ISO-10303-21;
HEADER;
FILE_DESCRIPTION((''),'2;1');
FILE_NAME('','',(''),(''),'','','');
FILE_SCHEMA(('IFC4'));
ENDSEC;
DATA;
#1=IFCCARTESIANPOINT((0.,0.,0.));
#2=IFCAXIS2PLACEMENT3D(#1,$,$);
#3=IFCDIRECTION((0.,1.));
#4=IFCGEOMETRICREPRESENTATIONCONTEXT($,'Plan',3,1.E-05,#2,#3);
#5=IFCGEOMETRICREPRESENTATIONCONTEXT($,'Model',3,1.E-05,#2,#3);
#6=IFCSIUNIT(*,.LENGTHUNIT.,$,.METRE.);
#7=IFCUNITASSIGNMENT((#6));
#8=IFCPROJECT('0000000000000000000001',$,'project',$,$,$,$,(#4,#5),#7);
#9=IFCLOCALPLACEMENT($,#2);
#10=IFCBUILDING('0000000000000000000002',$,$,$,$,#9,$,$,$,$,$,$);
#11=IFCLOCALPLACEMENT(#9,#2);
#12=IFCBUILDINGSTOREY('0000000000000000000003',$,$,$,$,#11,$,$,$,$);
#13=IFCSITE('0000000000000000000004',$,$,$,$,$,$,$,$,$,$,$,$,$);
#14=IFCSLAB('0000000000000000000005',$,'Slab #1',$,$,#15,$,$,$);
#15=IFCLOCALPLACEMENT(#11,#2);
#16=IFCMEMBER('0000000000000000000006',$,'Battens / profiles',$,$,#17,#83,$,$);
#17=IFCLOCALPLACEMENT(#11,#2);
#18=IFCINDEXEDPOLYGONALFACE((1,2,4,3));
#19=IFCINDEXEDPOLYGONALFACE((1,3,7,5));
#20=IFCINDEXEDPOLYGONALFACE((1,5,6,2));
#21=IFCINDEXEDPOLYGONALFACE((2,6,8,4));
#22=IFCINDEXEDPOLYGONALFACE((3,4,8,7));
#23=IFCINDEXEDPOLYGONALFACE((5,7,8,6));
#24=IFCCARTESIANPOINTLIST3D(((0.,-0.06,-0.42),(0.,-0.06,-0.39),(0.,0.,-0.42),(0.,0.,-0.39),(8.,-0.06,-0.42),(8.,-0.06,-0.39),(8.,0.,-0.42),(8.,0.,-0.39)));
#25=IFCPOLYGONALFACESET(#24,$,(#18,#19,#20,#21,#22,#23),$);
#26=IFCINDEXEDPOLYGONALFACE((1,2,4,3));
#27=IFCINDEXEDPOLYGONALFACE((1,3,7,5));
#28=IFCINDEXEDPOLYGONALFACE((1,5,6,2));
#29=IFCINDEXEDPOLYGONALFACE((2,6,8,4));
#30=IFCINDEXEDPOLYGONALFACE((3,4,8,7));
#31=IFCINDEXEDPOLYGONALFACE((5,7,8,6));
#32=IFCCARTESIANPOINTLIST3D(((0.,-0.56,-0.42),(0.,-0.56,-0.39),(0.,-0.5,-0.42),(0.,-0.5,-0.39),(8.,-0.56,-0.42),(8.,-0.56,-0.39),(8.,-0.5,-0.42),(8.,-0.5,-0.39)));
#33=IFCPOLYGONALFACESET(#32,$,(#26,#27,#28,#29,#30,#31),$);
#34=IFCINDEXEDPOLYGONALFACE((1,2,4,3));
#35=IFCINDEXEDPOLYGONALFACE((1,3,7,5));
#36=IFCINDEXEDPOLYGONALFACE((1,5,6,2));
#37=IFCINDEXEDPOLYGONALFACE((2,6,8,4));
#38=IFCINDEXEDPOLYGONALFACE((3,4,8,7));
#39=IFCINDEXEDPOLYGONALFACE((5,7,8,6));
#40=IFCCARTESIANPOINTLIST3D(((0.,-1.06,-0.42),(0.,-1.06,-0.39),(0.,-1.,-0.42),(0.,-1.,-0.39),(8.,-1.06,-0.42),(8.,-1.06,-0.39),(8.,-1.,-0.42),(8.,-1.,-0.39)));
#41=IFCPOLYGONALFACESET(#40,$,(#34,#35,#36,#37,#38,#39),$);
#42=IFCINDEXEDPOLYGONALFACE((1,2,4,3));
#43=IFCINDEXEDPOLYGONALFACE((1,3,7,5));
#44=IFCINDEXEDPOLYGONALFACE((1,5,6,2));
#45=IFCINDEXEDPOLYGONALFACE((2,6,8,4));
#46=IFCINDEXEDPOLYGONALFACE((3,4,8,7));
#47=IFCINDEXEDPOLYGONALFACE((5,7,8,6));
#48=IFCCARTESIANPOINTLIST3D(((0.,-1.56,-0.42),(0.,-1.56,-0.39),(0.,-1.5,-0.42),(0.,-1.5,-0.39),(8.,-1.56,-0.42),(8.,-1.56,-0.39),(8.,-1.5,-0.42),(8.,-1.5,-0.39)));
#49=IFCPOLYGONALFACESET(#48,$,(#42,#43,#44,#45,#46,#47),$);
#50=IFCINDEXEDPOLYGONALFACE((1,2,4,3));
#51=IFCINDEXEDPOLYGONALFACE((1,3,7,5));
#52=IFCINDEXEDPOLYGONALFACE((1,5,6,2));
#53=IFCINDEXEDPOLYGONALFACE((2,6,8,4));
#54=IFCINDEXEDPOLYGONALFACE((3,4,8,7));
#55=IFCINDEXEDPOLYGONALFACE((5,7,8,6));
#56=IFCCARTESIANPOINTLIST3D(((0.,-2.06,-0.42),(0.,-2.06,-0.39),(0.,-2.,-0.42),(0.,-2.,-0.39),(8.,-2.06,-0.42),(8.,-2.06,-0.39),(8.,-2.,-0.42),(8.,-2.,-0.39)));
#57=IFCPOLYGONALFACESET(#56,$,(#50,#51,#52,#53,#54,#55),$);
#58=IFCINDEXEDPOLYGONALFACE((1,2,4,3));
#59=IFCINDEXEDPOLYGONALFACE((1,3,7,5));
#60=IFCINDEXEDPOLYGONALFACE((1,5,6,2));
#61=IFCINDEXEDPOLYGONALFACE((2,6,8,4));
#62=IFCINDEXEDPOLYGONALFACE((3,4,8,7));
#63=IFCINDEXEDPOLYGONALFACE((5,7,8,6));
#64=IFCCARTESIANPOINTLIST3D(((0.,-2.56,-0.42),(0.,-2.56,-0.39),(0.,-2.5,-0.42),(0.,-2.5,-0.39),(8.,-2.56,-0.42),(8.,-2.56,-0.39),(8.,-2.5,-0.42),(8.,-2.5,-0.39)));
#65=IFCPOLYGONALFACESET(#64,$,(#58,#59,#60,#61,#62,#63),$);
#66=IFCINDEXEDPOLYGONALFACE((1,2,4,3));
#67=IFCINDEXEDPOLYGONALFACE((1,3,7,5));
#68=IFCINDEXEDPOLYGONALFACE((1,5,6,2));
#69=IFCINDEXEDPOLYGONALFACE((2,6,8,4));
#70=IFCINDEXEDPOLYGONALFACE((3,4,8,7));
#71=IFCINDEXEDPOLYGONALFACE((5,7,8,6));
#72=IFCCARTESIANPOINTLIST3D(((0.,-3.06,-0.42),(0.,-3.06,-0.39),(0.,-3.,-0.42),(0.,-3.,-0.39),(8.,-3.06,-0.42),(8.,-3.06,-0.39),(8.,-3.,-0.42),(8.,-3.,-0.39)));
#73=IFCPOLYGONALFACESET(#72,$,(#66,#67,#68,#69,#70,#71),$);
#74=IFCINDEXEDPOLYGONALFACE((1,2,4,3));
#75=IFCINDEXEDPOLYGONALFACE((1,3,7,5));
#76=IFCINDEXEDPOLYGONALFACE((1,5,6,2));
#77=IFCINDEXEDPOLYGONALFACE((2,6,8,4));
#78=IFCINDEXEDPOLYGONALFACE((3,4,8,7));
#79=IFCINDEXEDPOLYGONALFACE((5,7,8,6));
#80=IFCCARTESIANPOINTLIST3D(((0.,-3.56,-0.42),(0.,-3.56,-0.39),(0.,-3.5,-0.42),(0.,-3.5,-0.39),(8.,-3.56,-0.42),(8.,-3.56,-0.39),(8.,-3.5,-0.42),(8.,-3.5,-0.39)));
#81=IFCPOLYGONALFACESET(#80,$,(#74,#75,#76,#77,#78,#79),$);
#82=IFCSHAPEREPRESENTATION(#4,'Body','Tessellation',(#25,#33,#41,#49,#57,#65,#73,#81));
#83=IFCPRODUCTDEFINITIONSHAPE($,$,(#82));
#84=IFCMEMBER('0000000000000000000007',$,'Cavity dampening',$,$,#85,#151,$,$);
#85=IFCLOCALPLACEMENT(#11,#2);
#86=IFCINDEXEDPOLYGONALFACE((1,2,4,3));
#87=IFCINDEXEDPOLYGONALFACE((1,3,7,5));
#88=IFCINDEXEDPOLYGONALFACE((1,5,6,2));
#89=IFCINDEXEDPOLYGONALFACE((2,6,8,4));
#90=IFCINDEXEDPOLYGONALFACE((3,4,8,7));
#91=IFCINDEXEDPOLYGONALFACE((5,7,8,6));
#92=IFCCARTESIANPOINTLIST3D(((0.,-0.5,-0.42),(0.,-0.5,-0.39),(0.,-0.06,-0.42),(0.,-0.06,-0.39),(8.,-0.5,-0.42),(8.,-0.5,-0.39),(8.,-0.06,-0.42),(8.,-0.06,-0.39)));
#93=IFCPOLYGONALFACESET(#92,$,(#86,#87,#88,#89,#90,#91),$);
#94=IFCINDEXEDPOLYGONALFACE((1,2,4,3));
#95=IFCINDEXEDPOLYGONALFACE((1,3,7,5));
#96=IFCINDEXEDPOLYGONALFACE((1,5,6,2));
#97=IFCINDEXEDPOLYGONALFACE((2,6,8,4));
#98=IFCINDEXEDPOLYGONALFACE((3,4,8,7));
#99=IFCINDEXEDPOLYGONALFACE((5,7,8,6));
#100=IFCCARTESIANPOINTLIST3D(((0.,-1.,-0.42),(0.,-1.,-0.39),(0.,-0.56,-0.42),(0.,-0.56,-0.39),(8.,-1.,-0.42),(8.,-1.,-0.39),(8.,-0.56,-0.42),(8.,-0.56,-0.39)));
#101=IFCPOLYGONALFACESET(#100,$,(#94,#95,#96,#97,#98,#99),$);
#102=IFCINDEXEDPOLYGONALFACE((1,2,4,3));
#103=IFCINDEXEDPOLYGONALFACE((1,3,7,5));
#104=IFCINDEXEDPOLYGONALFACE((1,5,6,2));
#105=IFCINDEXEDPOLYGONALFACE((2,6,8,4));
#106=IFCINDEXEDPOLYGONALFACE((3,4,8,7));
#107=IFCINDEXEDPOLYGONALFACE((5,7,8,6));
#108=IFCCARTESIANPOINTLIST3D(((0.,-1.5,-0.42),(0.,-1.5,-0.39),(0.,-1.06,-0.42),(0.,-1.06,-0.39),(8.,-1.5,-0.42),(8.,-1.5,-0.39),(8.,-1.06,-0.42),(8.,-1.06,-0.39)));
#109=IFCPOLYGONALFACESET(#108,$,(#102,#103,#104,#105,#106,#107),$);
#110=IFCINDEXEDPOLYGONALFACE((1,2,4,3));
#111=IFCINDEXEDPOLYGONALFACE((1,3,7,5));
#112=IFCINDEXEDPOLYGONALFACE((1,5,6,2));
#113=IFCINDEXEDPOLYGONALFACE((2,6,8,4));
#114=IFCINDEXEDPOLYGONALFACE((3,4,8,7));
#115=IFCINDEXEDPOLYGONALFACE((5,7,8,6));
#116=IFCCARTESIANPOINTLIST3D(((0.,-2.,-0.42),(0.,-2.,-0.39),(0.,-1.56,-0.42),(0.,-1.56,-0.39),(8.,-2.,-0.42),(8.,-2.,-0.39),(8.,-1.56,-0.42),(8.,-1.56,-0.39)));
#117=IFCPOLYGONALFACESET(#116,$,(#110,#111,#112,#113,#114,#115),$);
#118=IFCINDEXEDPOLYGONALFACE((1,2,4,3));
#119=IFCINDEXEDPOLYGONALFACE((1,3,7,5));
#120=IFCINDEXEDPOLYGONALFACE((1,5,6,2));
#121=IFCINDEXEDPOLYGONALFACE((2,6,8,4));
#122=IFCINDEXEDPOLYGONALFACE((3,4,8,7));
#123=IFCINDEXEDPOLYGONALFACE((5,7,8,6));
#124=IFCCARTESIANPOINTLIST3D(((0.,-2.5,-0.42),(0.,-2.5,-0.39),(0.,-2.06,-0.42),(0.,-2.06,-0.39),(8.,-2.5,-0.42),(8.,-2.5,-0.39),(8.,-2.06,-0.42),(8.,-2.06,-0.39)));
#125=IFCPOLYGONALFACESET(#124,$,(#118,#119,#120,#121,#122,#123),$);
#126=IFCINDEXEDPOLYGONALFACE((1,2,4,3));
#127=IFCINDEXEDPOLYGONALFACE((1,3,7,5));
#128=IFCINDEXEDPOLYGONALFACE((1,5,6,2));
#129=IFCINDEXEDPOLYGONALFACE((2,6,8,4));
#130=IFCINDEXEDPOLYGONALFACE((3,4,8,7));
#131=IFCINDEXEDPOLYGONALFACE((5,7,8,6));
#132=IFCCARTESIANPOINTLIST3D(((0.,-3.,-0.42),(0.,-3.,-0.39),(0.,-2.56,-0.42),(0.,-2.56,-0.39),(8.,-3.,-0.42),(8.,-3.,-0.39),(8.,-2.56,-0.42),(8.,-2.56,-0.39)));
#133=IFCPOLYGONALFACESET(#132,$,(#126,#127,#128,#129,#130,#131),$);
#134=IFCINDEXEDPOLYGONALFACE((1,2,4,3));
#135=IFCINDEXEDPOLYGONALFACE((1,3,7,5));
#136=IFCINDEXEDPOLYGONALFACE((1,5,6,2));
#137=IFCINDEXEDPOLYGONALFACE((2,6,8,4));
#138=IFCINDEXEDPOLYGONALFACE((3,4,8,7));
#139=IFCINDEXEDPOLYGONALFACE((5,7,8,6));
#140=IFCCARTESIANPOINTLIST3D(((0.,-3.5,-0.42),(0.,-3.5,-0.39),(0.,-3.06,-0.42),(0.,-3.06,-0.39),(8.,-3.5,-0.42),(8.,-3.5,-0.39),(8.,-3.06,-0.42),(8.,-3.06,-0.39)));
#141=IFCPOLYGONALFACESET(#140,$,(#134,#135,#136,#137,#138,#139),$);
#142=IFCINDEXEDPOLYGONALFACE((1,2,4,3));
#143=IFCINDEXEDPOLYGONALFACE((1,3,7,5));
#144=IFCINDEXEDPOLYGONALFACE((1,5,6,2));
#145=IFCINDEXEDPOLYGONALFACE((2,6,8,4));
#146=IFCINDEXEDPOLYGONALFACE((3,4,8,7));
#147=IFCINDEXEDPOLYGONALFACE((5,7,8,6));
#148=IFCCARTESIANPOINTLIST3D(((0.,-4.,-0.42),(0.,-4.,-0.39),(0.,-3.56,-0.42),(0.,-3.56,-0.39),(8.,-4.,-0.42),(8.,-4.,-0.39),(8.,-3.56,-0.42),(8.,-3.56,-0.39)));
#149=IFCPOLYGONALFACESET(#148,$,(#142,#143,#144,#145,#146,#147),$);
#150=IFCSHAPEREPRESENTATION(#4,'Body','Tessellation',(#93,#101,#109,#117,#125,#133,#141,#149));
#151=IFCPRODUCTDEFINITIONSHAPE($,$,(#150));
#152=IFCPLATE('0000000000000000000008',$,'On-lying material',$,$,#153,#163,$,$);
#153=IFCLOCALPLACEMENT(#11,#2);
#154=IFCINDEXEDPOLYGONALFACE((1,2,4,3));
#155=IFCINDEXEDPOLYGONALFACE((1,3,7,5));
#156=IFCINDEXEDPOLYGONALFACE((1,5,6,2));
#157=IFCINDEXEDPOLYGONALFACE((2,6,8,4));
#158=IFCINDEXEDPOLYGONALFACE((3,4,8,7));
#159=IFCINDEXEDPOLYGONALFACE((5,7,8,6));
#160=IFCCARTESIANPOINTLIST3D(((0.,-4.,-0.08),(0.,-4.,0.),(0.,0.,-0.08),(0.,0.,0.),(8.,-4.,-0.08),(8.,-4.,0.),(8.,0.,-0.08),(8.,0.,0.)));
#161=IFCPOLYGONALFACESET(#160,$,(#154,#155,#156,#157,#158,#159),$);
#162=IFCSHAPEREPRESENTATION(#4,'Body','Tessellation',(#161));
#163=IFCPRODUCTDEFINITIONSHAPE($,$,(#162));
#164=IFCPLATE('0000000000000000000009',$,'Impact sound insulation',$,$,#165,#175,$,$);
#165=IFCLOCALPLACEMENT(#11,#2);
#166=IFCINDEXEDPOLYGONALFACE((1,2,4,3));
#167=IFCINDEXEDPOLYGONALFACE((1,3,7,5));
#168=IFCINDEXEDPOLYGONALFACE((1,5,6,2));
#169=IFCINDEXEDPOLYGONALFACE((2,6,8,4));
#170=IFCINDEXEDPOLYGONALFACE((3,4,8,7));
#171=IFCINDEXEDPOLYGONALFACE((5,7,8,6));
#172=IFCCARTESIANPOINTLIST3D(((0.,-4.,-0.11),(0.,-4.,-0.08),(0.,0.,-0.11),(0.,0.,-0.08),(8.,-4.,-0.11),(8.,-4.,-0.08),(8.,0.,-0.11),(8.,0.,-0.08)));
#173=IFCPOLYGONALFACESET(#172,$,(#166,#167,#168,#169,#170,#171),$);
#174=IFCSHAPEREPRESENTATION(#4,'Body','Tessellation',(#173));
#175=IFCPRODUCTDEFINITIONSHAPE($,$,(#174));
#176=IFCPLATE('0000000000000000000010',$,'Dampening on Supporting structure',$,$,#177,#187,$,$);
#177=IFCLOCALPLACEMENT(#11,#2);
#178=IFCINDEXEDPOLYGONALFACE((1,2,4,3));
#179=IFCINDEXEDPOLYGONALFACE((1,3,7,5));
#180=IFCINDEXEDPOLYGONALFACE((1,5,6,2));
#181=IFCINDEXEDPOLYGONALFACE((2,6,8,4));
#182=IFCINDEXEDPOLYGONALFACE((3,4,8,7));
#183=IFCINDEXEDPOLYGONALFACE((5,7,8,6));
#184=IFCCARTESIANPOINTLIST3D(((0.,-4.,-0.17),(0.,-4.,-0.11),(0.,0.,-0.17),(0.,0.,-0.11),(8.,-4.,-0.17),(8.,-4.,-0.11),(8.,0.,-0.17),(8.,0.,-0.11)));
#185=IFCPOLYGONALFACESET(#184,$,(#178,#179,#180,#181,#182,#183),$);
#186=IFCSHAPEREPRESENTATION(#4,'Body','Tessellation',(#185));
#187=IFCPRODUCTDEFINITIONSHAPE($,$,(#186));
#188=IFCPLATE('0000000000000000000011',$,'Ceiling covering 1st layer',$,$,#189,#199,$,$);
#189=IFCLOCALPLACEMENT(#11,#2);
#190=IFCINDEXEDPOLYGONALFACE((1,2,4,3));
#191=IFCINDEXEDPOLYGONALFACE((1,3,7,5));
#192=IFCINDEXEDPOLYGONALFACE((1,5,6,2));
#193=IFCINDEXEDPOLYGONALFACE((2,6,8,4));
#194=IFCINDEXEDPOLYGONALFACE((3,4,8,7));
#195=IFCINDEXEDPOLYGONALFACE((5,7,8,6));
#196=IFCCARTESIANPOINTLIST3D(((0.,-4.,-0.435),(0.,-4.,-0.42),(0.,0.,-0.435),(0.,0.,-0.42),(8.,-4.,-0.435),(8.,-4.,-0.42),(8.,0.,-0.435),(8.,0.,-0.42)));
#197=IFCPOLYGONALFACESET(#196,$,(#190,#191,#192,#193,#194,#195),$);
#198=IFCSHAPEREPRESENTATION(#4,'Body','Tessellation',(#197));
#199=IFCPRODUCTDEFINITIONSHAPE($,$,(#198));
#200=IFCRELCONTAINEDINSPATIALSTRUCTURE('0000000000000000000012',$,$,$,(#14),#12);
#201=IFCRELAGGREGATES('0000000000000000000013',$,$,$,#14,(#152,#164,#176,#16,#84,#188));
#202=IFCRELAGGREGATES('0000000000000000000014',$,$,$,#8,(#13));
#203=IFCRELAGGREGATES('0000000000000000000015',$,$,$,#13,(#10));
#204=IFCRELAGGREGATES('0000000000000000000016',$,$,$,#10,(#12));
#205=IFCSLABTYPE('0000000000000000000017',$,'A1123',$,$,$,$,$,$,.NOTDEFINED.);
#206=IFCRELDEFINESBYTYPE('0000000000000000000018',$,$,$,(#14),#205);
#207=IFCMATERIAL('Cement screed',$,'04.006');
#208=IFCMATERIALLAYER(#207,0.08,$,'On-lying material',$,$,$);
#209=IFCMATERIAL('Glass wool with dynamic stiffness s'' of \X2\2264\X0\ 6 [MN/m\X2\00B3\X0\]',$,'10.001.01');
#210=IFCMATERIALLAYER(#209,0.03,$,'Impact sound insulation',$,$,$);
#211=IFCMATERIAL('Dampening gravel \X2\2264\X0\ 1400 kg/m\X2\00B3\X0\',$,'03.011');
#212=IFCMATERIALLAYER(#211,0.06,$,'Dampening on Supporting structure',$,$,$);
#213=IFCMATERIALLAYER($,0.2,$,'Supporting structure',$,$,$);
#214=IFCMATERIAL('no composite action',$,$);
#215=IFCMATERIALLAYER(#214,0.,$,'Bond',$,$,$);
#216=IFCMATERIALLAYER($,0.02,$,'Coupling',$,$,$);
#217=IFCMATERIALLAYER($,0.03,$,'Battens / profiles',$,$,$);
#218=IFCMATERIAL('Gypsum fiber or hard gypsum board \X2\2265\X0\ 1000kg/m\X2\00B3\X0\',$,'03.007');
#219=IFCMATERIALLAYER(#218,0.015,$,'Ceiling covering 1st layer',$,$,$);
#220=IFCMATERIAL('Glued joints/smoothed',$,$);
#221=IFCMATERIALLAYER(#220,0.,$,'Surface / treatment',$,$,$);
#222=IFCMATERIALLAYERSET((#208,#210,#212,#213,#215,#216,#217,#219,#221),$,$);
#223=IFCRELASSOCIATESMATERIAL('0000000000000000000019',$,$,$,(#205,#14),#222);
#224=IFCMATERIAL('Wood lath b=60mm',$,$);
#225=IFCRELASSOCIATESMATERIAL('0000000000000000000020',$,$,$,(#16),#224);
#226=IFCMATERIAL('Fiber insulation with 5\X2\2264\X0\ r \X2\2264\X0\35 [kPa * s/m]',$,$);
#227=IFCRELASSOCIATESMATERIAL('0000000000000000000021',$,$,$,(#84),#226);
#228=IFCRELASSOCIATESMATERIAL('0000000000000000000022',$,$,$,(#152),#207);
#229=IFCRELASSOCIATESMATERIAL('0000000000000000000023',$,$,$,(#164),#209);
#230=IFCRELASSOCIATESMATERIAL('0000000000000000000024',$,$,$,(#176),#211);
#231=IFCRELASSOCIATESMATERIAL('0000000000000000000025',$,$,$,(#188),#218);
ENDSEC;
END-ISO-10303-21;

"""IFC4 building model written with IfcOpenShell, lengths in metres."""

from ifc_helpers import new_model, si_unit, direction, frame, frame_2d, origin, origin_with_axes, place, context, project, spatial, rectangle, extrude, material, layer, layer_set, type_object, element, aggregate, save


model = new_model("IFC4")

# Units and contexts
plan_context = context("Plan", 3, precision=1e-05, world=origin(), true_north=direction((0.0, 1.0)))
model_context = context("Model", 3, precision=1e-05, world=origin(), true_north=direction((0.0, 1.0)))
ifc_project = project(units=[si_unit("LENGTHUNIT", "METRE")], contexts=[plan_context, model_context])

# Site, building, storey
site = spatial("IfcSite", under=ifc_project)
building_placement = place(None, origin())
building = spatial("IfcBuilding", under=site, at=building_placement)
storey_placement = place(building_placement, origin())
storey = spatial("IfcBuildingStorey", under=building, at=storey_placement)

# Slab, members, plates
ifc_material_1 = material(Name="Cement screed", Category="04.006")
ifc_layer_1 = layer(ifc_material_1, 0.08, Name="On-lying material")
ifc_material_2 = material(Name="Glass wool with dynamic stiffness s' of ≤ 6 [MN/m³]", Category="10.001.01")
ifc_layer_2 = layer(ifc_material_2, 0.03, Name="Impact sound insulation")
ifc_material_3 = material(Name="Dampening gravel ≤ 1400 kg/m³", Category="03.011")
ifc_layer_3 = layer(ifc_material_3, 0.06, Name="Dampening on Supporting structure")
ifc_layer_4 = layer(None, 0.2, Name="Supporting structure")
ifc_material_4 = material(Name="no composite action")
ifc_layer_5 = layer(ifc_material_4, 0.0, Name="Bond")
ifc_layer_6 = layer(None, 0.02, Name="Coupling")
ifc_layer_7 = layer(None, 0.03, Name="Battens / profiles")
ifc_material_5 = material(Name="Gypsum fiber or hard gypsum board ≥ 1000kg/m³", Category="03.007")
ifc_layer_8 = layer(ifc_material_5, 0.015, Name="Ceiling covering 1st layer")
ifc_material_6 = material(Name="Glued joints/smoothed")
ifc_layer_9 = layer(ifc_material_6, 0.0, Name="Surface / treatment")
ifc_layer_set = layer_set([ifc_layer_1, ifc_layer_2, ifc_layer_3, ifc_layer_4, ifc_layer_5, ifc_layer_6, ifc_layer_7, ifc_layer_8, ifc_layer_9])
slab_type = type_object("IfcSlabType", Name="A1123", PredefinedType="NOTDEFINED", material=ifc_layer_set)
slab_placement = place(None, frame((0.0, 0.0, 0.0), z_axis=(0.0, 0.0, -1.0), x_axis=(1.0, 0.0, 0.0)))
slab = element("IfcSlab", 1, at=slab_placement, inside=storey, type_object=slab_type, material=ifc_layer_set, Name="Slab #1")
ifc_material_7 = material(Name="Wood lath b=60mm")
member_1_placement = place(slab_placement, origin())
member_1 = element("IfcMember", 2, at=member_1_placement, material=ifc_material_7, Name="Battens / profiles", context=plan_context, shape_type="SweptSolid", body=[
    extrude(rectangle(XDim=0.06, YDim=0.03, at=frame_2d((0.03, 0.015), x_axis=(1.0, 0.0))), frame((0.0, 0.0, 0.39), z_axis=(1.0, 0.0, 0.0), x_axis=(0.0, 1.0, 0.0)), (0.0, 0.0, 1.0), 8.0),
    extrude(rectangle(XDim=0.06, YDim=0.03, at=frame_2d((0.03, 0.015), x_axis=(1.0, 0.0))), frame((0.0, 0.5, 0.39), z_axis=(1.0, 0.0, 0.0), x_axis=(0.0, 1.0, 0.0)), (0.0, 0.0, 1.0), 8.0),
    extrude(rectangle(XDim=0.06, YDim=0.03, at=frame_2d((0.03, 0.015), x_axis=(1.0, 0.0))), frame((0.0, 1.0, 0.39), z_axis=(1.0, 0.0, 0.0), x_axis=(0.0, 1.0, 0.0)), (0.0, 0.0, 1.0), 8.0),
    extrude(rectangle(XDim=0.06, YDim=0.03, at=frame_2d((0.03, 0.015), x_axis=(1.0, 0.0))), frame((0.0, 1.5, 0.39), z_axis=(1.0, 0.0, 0.0), x_axis=(0.0, 1.0, 0.0)), (0.0, 0.0, 1.0), 8.0),
    extrude(rectangle(XDim=0.06, YDim=0.03, at=frame_2d((0.03, 0.015), x_axis=(1.0, 0.0))), frame((0.0, 2.0, 0.39), z_axis=(1.0, 0.0, 0.0), x_axis=(0.0, 1.0, 0.0)), (0.0, 0.0, 1.0), 8.0),
    extrude(rectangle(XDim=0.06, YDim=0.03, at=frame_2d((0.03, 0.015), x_axis=(1.0, 0.0))), frame((0.0, 2.5, 0.39), z_axis=(1.0, 0.0, 0.0), x_axis=(0.0, 1.0, 0.0)), (0.0, 0.0, 1.0), 8.0),
    extrude(rectangle(XDim=0.06, YDim=0.03, at=frame_2d((0.03, 0.015), x_axis=(1.0, 0.0))), frame((0.0, 3.0, 0.39), z_axis=(1.0, 0.0, 0.0), x_axis=(0.0, 1.0, 0.0)), (0.0, 0.0, 1.0), 8.0),
    extrude(rectangle(XDim=0.06, YDim=0.03, at=frame_2d((0.03, 0.015), x_axis=(1.0, 0.0))), frame((0.0, 3.5, 0.39), z_axis=(1.0, 0.0, 0.0), x_axis=(0.0, 1.0, 0.0)), (0.0, 0.0, 1.0), 8.0),
])
ifc_material_8 = material(Name="Fiber insulation with 5≤ r ≤35 [kPa * s/m]")
member_2_placement = place(slab_placement, origin())
member_2 = element("IfcMember", 3, at=member_2_placement, material=ifc_material_8, Name="Cavity dampening", context=plan_context, shape_type="SweptSolid", body=[
    extrude(rectangle(XDim=0.44, YDim=0.03, at=frame_2d((0.22, 0.015), x_axis=(1.0, 0.0))), frame((0.0, 0.06, 0.39), z_axis=(1.0, 0.0, 0.0), x_axis=(0.0, 1.0, 0.0)), (0.0, 0.0, 1.0), 8.0),
    extrude(rectangle(XDim=0.44, YDim=0.03, at=frame_2d((0.22, 0.015), x_axis=(1.0, 0.0))), frame((0.0, 0.56, 0.39), z_axis=(1.0, 0.0, 0.0), x_axis=(0.0, 1.0, 0.0)), (0.0, 0.0, 1.0), 8.0),
    extrude(rectangle(XDim=0.44, YDim=0.03, at=frame_2d((0.22, 0.015), x_axis=(1.0, 0.0))), frame((0.0, 1.06, 0.39), z_axis=(1.0, 0.0, 0.0), x_axis=(0.0, 1.0, 0.0)), (0.0, 0.0, 1.0), 8.0),
    extrude(rectangle(XDim=0.44, YDim=0.03, at=frame_2d((0.22, 0.015), x_axis=(1.0, 0.0))), frame((0.0, 1.56, 0.39), z_axis=(1.0, 0.0, 0.0), x_axis=(0.0, 1.0, 0.0)), (0.0, 0.0, 1.0), 8.0),
    extrude(rectangle(XDim=0.44, YDim=0.03, at=frame_2d((0.22, 0.015), x_axis=(1.0, 0.0))), frame((0.0, 2.06, 0.39), z_axis=(1.0, 0.0, 0.0), x_axis=(0.0, 1.0, 0.0)), (0.0, 0.0, 1.0), 8.0),
    extrude(rectangle(XDim=0.44, YDim=0.03, at=frame_2d((0.22, 0.015), x_axis=(1.0, 0.0))), frame((0.0, 2.56, 0.39), z_axis=(1.0, 0.0, 0.0), x_axis=(0.0, 1.0, 0.0)), (0.0, 0.0, 1.0), 8.0),
    extrude(rectangle(XDim=0.44, YDim=0.03, at=frame_2d((0.22, 0.015), x_axis=(1.0, 0.0))), frame((0.0, 3.06, 0.39), z_axis=(1.0, 0.0, 0.0), x_axis=(0.0, 1.0, 0.0)), (0.0, 0.0, 1.0), 8.0),
    extrude(rectangle(XDim=0.44, YDim=0.03, at=frame_2d((0.22, 0.015), x_axis=(1.0, 0.0))), frame((0.0, 3.56, 0.39), z_axis=(1.0, 0.0, 0.0), x_axis=(0.0, 1.0, 0.0)), (0.0, 0.0, 1.0), 8.0),
])
plate_1_placement = place(slab_placement, origin())
plate_1 = element("IfcPlate", 4, at=plate_1_placement, material=ifc_material_1, Name="On-lying material", context=plan_context, shape_type="SweptSolid", body=[
    extrude(rectangle(XDim=8.0, YDim=4.0, at=frame_2d((4.0, 2.0), x_axis=(1.0, 0.0))), origin_with_axes(), (0.0, 0.0, 1.0), 0.08),
])
plate_2_placement = place(slab_placement, origin())
plate_2 = element("IfcPlate", 5, at=plate_2_placement, material=ifc_material_2, Name="Impact sound insulation", context=plan_context, shape_type="SweptSolid", body=[
    extrude(rectangle(XDim=8.0, YDim=4.0, at=frame_2d((4.0, 2.0), x_axis=(1.0, 0.0))), frame((0.0, 0.0, 0.08), z_axis=(0.0, 0.0, 1.0), x_axis=(1.0, 0.0, 0.0)), (0.0, 0.0, 1.0), 0.03),
])
plate_3_placement = place(slab_placement, origin())
plate_3 = element("IfcPlate", 6, at=plate_3_placement, material=ifc_material_3, Name="Dampening on Supporting structure", context=plan_context, shape_type="SweptSolid", body=[
    extrude(rectangle(XDim=8.0, YDim=4.0, at=frame_2d((4.0, 2.0), x_axis=(1.0, 0.0))), frame((0.0, 0.0, 0.11), z_axis=(0.0, 0.0, 1.0), x_axis=(1.0, 0.0, 0.0)), (0.0, 0.0, 1.0), 0.06),
])
plate_4_placement = place(slab_placement, origin())
plate_4 = element("IfcPlate", 7, at=plate_4_placement, material=ifc_material_5, Name="Ceiling covering 1st layer", context=plan_context, shape_type="SweptSolid", body=[
    extrude(rectangle(XDim=8.0, YDim=4.0, at=frame_2d((4.0, 2.0), x_axis=(1.0, 0.0))), frame((0.0, 0.0, 0.42), z_axis=(0.0, 0.0, 1.0), x_axis=(1.0, 0.0, 0.0)), (0.0, 0.0, 1.0), 0.015),
])
aggregate(slab, [plate_1, plate_2, plate_3, member_1, member_2, plate_4])

save(model, "model.ifc")
